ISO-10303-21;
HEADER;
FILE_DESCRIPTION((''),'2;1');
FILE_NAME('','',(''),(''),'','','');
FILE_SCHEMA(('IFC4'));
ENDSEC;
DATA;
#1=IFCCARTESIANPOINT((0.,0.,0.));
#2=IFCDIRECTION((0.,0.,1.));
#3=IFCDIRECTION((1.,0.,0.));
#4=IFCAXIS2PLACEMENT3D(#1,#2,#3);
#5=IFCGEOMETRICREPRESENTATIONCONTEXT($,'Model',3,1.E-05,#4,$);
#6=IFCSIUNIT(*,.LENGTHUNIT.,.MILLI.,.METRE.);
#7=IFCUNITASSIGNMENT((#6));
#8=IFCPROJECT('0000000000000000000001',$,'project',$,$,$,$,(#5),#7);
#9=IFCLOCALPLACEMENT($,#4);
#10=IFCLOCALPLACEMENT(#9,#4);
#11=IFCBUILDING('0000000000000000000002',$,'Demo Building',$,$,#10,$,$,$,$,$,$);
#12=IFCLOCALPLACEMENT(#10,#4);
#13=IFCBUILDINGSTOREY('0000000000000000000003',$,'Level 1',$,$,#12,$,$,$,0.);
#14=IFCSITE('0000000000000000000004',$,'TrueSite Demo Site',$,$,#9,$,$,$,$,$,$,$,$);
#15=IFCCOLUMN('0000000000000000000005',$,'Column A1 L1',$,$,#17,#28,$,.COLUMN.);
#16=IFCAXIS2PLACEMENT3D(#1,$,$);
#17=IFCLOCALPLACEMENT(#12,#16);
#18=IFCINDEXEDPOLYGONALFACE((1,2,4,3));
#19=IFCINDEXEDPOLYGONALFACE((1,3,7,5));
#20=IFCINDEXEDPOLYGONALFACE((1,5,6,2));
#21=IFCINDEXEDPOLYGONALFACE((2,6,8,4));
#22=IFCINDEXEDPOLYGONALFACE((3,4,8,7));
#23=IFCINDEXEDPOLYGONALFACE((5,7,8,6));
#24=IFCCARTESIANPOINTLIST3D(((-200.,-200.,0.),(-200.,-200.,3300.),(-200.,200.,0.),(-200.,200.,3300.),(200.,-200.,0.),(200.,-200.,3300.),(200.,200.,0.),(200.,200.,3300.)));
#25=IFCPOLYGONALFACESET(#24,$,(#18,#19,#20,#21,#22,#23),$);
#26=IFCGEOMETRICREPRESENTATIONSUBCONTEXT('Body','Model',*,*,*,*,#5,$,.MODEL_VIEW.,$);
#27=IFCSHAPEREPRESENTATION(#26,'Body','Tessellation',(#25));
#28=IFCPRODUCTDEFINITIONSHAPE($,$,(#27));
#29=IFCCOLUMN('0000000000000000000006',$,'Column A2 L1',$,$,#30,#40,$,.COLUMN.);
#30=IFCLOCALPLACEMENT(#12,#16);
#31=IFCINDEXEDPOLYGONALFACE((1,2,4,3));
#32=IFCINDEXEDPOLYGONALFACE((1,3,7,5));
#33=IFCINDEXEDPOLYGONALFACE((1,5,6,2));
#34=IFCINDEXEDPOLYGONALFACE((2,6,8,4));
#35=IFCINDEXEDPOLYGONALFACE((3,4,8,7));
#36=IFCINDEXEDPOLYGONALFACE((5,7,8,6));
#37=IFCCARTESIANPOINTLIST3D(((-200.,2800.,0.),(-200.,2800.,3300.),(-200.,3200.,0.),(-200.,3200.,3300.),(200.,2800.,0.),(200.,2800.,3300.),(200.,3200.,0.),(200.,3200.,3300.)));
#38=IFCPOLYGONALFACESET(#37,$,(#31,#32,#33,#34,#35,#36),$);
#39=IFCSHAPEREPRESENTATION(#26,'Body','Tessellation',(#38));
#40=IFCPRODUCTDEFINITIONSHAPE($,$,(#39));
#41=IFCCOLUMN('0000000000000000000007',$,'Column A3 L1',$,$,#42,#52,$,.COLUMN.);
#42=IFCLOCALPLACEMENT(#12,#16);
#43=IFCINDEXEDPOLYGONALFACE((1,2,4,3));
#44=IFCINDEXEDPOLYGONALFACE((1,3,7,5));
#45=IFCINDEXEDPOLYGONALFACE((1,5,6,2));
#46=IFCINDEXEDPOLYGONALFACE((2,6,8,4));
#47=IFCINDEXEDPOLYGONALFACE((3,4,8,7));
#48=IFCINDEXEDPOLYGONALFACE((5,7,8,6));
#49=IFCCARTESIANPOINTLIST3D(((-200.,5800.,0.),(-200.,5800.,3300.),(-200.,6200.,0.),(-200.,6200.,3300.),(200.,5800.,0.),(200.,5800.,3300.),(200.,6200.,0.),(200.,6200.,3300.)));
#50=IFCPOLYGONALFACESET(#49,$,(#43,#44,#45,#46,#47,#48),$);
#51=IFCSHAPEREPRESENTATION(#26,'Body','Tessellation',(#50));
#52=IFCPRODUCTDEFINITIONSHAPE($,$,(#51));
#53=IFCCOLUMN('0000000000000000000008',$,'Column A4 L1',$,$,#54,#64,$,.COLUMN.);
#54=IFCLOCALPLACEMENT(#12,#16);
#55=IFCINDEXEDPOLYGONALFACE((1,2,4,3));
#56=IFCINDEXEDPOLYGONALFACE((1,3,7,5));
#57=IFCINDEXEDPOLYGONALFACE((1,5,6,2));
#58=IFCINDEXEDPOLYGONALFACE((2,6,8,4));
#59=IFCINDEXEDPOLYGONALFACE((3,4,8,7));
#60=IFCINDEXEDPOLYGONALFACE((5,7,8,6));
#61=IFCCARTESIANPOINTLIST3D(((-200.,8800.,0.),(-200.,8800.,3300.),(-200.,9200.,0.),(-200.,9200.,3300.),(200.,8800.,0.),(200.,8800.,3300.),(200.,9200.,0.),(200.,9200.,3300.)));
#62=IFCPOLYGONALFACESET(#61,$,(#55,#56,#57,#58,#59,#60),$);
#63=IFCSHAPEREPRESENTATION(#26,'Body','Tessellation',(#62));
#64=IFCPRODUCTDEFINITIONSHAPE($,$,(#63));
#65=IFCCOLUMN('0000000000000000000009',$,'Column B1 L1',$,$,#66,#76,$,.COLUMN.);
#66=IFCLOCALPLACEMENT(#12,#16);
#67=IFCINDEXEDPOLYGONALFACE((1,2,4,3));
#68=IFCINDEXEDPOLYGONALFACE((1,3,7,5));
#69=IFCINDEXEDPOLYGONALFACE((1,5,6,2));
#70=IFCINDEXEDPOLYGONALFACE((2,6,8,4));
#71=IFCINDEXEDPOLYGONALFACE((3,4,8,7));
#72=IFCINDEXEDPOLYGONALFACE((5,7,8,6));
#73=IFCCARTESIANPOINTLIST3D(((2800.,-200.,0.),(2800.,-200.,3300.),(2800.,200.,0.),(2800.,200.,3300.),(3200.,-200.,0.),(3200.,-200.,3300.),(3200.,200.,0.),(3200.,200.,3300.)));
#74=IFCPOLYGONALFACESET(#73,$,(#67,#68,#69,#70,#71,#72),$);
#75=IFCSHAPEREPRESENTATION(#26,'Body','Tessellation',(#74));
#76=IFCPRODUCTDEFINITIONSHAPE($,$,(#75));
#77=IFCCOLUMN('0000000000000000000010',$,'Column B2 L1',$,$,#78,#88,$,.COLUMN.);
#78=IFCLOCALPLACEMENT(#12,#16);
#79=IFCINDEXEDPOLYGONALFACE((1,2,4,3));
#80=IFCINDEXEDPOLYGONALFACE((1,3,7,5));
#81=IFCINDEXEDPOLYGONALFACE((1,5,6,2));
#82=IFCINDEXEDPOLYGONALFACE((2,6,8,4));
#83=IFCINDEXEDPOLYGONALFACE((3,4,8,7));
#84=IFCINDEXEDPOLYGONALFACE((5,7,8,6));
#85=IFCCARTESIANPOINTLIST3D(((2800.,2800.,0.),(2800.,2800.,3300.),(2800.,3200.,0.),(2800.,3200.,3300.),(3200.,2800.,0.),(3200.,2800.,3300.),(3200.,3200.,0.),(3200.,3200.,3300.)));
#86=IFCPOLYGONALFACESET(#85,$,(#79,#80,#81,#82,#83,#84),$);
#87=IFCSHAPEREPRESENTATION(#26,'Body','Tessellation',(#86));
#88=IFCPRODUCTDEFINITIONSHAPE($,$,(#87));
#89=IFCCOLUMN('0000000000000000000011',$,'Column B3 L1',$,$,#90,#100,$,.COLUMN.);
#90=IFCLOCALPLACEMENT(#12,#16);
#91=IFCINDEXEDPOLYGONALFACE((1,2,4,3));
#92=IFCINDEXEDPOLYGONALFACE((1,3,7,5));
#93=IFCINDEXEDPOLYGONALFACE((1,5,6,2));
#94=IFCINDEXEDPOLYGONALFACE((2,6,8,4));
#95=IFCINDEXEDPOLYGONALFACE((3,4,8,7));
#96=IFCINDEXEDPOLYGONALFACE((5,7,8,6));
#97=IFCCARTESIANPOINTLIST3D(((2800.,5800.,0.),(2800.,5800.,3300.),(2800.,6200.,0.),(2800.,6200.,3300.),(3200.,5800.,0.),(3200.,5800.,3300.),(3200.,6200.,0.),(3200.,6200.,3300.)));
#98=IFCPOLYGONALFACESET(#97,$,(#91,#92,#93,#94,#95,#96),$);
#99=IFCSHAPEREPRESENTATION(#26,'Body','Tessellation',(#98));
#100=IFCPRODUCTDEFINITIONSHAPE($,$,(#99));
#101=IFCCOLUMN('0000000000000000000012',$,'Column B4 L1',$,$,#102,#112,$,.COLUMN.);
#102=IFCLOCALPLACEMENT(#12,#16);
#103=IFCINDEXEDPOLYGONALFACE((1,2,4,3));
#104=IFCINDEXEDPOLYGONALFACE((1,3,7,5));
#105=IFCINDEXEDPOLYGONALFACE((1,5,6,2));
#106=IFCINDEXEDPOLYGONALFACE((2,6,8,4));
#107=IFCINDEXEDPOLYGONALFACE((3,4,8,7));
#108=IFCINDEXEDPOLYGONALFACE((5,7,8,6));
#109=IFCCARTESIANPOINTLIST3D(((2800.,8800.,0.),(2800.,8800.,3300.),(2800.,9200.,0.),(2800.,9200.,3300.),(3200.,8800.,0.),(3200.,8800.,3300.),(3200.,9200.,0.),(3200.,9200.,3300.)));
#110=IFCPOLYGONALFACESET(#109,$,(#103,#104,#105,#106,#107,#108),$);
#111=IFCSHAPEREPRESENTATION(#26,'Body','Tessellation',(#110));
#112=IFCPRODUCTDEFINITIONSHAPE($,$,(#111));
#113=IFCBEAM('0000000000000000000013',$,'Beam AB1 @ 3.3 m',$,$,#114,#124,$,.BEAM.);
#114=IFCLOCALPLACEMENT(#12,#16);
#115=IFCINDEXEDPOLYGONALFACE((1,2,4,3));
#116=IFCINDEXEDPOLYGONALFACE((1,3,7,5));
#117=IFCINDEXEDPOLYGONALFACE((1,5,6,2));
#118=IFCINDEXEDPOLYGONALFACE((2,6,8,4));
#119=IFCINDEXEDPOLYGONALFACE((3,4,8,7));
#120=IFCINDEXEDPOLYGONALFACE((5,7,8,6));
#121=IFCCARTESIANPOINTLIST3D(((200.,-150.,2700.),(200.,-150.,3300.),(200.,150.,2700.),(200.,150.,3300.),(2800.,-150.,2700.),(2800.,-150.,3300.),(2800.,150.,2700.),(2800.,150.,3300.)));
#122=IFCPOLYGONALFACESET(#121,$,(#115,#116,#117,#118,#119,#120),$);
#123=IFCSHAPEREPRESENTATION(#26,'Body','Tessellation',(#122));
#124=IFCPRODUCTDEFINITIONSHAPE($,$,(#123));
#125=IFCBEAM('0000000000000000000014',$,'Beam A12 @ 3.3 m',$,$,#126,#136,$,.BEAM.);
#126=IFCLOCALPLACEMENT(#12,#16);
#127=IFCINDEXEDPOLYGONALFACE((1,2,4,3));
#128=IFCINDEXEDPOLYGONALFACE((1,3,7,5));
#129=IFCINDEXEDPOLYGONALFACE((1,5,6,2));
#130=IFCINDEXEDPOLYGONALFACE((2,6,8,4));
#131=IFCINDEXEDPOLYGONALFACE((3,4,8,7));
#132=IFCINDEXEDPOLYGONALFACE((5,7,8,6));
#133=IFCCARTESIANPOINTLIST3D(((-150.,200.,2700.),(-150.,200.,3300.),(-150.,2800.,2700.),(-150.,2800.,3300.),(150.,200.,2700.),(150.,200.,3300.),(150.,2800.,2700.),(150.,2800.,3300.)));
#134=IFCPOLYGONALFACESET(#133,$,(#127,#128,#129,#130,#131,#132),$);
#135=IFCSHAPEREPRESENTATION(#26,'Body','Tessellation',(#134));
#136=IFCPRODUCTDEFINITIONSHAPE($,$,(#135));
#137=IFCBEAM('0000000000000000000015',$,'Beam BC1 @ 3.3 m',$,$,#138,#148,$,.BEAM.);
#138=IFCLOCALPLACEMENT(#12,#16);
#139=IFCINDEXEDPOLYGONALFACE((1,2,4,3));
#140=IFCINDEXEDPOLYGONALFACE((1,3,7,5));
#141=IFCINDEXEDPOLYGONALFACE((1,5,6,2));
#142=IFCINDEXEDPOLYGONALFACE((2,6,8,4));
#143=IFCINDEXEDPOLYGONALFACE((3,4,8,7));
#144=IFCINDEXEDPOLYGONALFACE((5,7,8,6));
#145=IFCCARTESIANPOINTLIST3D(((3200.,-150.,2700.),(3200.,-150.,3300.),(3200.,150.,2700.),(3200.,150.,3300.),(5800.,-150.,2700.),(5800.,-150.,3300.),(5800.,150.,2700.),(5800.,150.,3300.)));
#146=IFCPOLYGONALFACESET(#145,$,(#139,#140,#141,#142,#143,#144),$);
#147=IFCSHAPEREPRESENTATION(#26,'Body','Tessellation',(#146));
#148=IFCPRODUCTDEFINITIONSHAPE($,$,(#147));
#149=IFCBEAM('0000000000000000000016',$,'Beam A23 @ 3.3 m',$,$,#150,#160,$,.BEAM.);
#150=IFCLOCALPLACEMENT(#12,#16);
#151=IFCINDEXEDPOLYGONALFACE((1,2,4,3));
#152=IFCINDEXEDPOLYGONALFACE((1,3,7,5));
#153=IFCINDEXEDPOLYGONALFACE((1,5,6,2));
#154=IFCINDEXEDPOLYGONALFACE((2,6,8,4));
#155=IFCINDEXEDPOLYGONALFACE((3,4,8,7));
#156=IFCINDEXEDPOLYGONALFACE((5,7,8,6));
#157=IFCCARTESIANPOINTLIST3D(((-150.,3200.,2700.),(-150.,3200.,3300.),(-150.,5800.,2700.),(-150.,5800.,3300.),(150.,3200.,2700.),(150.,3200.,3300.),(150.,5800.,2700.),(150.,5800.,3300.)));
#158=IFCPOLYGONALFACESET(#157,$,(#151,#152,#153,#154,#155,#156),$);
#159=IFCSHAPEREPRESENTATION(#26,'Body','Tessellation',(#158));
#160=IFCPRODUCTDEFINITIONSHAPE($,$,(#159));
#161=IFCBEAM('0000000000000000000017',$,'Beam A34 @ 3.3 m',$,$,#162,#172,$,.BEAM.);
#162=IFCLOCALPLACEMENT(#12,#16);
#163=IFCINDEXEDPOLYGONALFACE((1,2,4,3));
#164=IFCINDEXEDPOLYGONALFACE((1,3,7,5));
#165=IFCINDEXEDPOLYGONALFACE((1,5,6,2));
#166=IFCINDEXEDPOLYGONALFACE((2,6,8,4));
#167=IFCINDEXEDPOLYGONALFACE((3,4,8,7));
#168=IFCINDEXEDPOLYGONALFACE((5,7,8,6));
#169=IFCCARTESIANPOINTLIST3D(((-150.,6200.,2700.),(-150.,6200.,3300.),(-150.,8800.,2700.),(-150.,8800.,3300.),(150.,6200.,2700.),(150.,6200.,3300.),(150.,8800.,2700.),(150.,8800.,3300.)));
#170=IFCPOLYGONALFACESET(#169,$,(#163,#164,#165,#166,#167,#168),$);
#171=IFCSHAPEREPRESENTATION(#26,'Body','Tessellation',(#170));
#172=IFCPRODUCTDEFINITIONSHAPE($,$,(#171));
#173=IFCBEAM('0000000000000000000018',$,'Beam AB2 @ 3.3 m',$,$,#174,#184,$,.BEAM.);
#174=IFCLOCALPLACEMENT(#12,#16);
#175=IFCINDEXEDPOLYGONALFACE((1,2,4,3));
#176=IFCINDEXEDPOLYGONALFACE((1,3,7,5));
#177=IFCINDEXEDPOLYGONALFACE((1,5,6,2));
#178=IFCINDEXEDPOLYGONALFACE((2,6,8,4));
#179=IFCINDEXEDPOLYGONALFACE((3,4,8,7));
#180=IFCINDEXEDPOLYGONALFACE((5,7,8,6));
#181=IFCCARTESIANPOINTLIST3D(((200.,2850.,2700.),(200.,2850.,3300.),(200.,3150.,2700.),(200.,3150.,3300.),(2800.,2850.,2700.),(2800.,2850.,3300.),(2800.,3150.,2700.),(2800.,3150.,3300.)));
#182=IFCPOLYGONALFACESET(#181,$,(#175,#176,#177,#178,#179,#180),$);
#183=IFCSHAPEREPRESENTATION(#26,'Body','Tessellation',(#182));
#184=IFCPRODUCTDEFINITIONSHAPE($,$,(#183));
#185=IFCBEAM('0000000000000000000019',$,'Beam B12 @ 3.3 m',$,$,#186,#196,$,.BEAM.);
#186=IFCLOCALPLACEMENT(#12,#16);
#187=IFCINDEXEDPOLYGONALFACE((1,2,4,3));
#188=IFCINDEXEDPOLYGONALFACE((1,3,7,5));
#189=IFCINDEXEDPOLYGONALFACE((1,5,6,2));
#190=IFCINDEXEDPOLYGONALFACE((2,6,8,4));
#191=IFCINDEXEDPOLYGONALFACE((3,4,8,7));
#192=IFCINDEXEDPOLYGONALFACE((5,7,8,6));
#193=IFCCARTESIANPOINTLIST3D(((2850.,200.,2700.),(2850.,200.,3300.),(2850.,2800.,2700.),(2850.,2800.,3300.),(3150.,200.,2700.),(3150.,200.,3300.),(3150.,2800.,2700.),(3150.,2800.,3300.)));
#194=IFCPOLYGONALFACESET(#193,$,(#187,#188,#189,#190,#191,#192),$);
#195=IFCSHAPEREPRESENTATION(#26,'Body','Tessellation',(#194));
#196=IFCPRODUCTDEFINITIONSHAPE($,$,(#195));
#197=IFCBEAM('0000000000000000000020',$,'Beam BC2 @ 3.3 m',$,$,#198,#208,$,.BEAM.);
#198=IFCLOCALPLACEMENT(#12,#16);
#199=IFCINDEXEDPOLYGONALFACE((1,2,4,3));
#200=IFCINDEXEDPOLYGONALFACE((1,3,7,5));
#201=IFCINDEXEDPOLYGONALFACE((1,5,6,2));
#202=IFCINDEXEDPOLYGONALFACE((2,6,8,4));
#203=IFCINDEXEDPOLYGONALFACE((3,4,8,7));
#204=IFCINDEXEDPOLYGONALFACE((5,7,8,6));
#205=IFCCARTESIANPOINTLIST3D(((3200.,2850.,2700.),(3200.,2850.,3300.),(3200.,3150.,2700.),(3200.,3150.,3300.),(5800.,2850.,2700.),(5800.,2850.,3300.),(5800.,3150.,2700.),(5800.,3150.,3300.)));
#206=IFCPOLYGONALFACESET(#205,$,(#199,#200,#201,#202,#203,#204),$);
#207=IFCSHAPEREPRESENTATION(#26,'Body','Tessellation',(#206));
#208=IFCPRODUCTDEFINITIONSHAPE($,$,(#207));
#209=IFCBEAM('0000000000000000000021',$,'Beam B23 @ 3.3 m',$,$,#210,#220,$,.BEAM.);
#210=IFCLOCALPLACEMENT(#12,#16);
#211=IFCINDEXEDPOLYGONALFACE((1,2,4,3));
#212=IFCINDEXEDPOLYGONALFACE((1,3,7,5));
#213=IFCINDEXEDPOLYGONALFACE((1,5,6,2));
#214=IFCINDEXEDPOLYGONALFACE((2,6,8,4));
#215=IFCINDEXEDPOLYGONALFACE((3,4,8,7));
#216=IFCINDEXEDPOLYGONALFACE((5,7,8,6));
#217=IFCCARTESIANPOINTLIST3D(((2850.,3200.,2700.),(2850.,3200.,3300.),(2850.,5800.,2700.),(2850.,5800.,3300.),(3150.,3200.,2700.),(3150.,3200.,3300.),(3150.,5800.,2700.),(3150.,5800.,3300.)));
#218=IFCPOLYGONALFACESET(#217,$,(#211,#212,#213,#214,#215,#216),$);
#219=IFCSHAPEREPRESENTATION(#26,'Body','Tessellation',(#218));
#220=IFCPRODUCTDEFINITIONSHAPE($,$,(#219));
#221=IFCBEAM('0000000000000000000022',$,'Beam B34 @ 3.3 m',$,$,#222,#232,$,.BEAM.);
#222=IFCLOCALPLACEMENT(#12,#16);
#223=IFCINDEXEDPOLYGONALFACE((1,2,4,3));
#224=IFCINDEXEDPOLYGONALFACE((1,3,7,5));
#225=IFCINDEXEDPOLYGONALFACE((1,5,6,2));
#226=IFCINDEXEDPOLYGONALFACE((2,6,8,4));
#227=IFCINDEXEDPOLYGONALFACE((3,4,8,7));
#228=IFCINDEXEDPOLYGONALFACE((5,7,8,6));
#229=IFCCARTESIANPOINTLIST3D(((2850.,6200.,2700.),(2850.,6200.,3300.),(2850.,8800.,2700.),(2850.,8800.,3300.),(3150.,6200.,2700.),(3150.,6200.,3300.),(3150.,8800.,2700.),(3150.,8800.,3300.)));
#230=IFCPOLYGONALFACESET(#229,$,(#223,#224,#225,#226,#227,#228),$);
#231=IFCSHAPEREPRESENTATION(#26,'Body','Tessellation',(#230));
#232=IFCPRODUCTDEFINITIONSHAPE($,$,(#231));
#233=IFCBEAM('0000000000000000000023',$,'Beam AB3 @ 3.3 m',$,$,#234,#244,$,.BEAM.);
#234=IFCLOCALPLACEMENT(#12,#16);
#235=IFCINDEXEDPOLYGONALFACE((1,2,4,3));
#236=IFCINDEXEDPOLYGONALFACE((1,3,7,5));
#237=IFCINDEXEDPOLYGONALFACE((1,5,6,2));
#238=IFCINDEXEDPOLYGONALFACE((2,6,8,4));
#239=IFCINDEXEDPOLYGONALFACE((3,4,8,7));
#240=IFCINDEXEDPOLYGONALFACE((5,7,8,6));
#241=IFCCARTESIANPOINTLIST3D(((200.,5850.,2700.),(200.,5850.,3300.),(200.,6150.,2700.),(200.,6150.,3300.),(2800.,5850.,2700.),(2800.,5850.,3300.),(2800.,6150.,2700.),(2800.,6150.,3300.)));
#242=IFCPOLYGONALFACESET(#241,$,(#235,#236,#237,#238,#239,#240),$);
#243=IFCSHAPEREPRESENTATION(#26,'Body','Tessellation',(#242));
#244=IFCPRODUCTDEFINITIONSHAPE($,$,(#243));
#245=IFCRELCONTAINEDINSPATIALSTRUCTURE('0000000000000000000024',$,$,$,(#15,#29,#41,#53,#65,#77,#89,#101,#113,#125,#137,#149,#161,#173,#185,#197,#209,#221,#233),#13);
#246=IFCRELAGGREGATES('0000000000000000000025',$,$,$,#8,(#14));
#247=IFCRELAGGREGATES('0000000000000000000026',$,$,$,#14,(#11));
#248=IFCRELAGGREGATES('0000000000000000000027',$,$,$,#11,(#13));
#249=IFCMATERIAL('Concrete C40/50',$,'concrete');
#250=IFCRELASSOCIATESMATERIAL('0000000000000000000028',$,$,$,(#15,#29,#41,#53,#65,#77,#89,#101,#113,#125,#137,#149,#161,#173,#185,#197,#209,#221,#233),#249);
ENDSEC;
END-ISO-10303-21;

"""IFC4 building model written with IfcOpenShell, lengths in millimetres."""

from ifc_helpers import new_model, si_unit, frame, origin_with_axes, place, context, subcontext, project, spatial, rectangle, extrude, material, element, save


model = new_model("IFC4")

# Units and contexts
model_context = context("Model", 3, precision=1e-05, world=origin_with_axes())
body_context = subcontext(model_context, "Body", "Model", "MODEL_VIEW")
ifc_project = project(units=[si_unit("LENGTHUNIT", "METRE", prefix="MILLI")], contexts=[model_context])

# Site, building, storey
site_placement = place(None, origin_with_axes())
site = spatial("IfcSite", under=ifc_project, at=site_placement, Name="TrueSite Demo Site")
building_placement = place(site_placement, origin_with_axes())
building = spatial("IfcBuilding", under=site, at=building_placement, Name="Demo Building")
storey_placement = place(building_placement, origin_with_axes())
storey = spatial("IfcBuildingStorey", under=building, at=storey_placement, Name="Level 1", Elevation=0.0)

# Columns
ifc_material_1 = material(Name="Concrete C40/50", Category="concrete")
for number, where, z_axis, x_axis, name in (
    (1, (0.0, 0.0, 0.0), (0.0, 0.0, 1.0), (1.0, 0.0, 0.0), "Column A1 L1"),
    (2, (0.0, 3000.0, 0.0), (0.0, 0.0, 1.0), (1.0, 0.0, 0.0), "Column A2 L1"),
    (3, (0.0, 6000.0, 0.0), (0.0, 0.0, 1.0), (1.0, 0.0, 0.0), "Column A3 L1"),
    (4, (0.0, 9000.0, 0.0), (0.0, 0.0, 1.0), (1.0, 0.0, 0.0), "Column A4 L1"),
    (5, (3000.0, 0.0, 0.0), (0.0, 0.0, 1.0), (1.0, 0.0, 0.0), "Column B1 L1"),
    (6, (3000.0, 3000.0, 0.0), (0.0, 0.0, 1.0), (1.0, 0.0, 0.0), "Column B2 L1"),
    (7, (3000.0, 6000.0, 0.0), (0.0, 0.0, 1.0), (1.0, 0.0, 0.0), "Column B3 L1"),
    (8, (3000.0, 9000.0, 0.0), (0.0, 0.0, 1.0), (1.0, 0.0, 0.0), "Column B4 L1"),
):
    element("IfcColumn", number, at=place(storey_placement, frame(where, z_axis=z_axis, x_axis=x_axis)), inside=storey, material=ifc_material_1, Name=name, PredefinedType="COLUMN", context=body_context, shape_type="SweptSolid", body=[
        extrude(rectangle(XDim=400.0, YDim=400.0), origin_with_axes(), (0.0, 0.0, 1.0), 3300.0),
    ])

# Beams
for number, where, z_axis, x_axis, name in (
    (9, (200.0, 0.0, 3000.0), (1.0, 0.0, 0.0), (0.0, 1.0, 0.0), "Beam AB1 @ 3.3 m"),
    (10, (0.0, 200.0, 3000.0), (0.0, 1.0, 0.0), (1.0, 0.0, 0.0), "Beam A12 @ 3.3 m"),
    (11, (3200.0, 0.0, 3000.0), (1.0, 0.0, 0.0), (0.0, 1.0, 0.0), "Beam BC1 @ 3.3 m"),
    (12, (0.0, 3200.0, 3000.0), (0.0, 1.0, 0.0), (1.0, 0.0, 0.0), "Beam A23 @ 3.3 m"),
):
    element("IfcBeam", number, at=place(storey_placement, frame(where, z_axis=z_axis, x_axis=x_axis)), inside=storey, material=ifc_material_1, Name=name, PredefinedType="BEAM", context=body_context, shape_type="SweptSolid", body=[
        extrude(rectangle(XDim=300.0, YDim=600.0), origin_with_axes(), (0.0, 0.0, 1.0), 2600.0),
    ])
beam_1_placement = place(storey_placement, frame((0.0, 6200.0, 3000.0), z_axis=(0.0, 1.0, 0.0), x_axis=(1.0, 0.0, 0.0)))
element("IfcBeam", 13, at=beam_1_placement, inside=storey, material=ifc_material_1, Name="Beam A34 @ 3.3 m", PredefinedType="BEAM", context=body_context, shape_type="SweptSolid", body=[
    extrude(rectangle(XDim=300.0, YDim=600.0), origin_with_axes(), (0.0, 0.0, 1.0), 2600.0),
])
for number, where, z_axis, x_axis, name in (
    (14, (200.0, 3000.0, 3000.0), (1.0, 0.0, 0.0), (0.0, 1.0, 0.0), "Beam AB2 @ 3.3 m"),
    (15, (3000.0, 200.0, 3000.0), (0.0, 1.0, 0.0), (1.0, 0.0, 0.0), "Beam B12 @ 3.3 m"),
    (16, (3200.0, 3000.0, 3000.0), (1.0, 0.0, 0.0), (0.0, 1.0, 0.0), "Beam BC2 @ 3.3 m"),
    (17, (3000.0, 3200.0, 3000.0), (0.0, 1.0, 0.0), (1.0, 0.0, 0.0), "Beam B23 @ 3.3 m"),
):
    element("IfcBeam", number, at=place(storey_placement, frame(where, z_axis=z_axis, x_axis=x_axis)), inside=storey, material=ifc_material_1, Name=name, PredefinedType="BEAM", context=body_context, shape_type="SweptSolid", body=[
        extrude(rectangle(XDim=300.0, YDim=600.0), origin_with_axes(), (0.0, 0.0, 1.0), 2600.0),
    ])
beam_2_placement = place(storey_placement, frame((3000.0, 6200.0, 3000.0), z_axis=(0.0, 1.0, 0.0), x_axis=(1.0, 0.0, 0.0)))
element("IfcBeam", 18, at=beam_2_placement, inside=storey, material=ifc_material_1, Name="Beam B34 @ 3.3 m", PredefinedType="BEAM", context=body_context, shape_type="SweptSolid", body=[
    extrude(rectangle(XDim=300.0, YDim=600.0), origin_with_axes(), (0.0, 0.0, 1.0), 2600.0),
])
for number, where, z_axis, x_axis, name in (
    (19, (200.0, 6000.0, 3000.0), (1.0, 0.0, 0.0), (0.0, 1.0, 0.0), "Beam AB3 @ 3.3 m"),
):
    element("IfcBeam", number, at=place(storey_placement, frame(where, z_axis=z_axis, x_axis=x_axis)), inside=storey, material=ifc_material_1, Name=name, PredefinedType="BEAM", context=body_context, shape_type="SweptSolid", body=[
        extrude(rectangle(XDim=300.0, YDim=600.0), origin_with_axes(), (0.0, 0.0, 1.0), 2600.0),
    ])

save(model, "model.ifc")
